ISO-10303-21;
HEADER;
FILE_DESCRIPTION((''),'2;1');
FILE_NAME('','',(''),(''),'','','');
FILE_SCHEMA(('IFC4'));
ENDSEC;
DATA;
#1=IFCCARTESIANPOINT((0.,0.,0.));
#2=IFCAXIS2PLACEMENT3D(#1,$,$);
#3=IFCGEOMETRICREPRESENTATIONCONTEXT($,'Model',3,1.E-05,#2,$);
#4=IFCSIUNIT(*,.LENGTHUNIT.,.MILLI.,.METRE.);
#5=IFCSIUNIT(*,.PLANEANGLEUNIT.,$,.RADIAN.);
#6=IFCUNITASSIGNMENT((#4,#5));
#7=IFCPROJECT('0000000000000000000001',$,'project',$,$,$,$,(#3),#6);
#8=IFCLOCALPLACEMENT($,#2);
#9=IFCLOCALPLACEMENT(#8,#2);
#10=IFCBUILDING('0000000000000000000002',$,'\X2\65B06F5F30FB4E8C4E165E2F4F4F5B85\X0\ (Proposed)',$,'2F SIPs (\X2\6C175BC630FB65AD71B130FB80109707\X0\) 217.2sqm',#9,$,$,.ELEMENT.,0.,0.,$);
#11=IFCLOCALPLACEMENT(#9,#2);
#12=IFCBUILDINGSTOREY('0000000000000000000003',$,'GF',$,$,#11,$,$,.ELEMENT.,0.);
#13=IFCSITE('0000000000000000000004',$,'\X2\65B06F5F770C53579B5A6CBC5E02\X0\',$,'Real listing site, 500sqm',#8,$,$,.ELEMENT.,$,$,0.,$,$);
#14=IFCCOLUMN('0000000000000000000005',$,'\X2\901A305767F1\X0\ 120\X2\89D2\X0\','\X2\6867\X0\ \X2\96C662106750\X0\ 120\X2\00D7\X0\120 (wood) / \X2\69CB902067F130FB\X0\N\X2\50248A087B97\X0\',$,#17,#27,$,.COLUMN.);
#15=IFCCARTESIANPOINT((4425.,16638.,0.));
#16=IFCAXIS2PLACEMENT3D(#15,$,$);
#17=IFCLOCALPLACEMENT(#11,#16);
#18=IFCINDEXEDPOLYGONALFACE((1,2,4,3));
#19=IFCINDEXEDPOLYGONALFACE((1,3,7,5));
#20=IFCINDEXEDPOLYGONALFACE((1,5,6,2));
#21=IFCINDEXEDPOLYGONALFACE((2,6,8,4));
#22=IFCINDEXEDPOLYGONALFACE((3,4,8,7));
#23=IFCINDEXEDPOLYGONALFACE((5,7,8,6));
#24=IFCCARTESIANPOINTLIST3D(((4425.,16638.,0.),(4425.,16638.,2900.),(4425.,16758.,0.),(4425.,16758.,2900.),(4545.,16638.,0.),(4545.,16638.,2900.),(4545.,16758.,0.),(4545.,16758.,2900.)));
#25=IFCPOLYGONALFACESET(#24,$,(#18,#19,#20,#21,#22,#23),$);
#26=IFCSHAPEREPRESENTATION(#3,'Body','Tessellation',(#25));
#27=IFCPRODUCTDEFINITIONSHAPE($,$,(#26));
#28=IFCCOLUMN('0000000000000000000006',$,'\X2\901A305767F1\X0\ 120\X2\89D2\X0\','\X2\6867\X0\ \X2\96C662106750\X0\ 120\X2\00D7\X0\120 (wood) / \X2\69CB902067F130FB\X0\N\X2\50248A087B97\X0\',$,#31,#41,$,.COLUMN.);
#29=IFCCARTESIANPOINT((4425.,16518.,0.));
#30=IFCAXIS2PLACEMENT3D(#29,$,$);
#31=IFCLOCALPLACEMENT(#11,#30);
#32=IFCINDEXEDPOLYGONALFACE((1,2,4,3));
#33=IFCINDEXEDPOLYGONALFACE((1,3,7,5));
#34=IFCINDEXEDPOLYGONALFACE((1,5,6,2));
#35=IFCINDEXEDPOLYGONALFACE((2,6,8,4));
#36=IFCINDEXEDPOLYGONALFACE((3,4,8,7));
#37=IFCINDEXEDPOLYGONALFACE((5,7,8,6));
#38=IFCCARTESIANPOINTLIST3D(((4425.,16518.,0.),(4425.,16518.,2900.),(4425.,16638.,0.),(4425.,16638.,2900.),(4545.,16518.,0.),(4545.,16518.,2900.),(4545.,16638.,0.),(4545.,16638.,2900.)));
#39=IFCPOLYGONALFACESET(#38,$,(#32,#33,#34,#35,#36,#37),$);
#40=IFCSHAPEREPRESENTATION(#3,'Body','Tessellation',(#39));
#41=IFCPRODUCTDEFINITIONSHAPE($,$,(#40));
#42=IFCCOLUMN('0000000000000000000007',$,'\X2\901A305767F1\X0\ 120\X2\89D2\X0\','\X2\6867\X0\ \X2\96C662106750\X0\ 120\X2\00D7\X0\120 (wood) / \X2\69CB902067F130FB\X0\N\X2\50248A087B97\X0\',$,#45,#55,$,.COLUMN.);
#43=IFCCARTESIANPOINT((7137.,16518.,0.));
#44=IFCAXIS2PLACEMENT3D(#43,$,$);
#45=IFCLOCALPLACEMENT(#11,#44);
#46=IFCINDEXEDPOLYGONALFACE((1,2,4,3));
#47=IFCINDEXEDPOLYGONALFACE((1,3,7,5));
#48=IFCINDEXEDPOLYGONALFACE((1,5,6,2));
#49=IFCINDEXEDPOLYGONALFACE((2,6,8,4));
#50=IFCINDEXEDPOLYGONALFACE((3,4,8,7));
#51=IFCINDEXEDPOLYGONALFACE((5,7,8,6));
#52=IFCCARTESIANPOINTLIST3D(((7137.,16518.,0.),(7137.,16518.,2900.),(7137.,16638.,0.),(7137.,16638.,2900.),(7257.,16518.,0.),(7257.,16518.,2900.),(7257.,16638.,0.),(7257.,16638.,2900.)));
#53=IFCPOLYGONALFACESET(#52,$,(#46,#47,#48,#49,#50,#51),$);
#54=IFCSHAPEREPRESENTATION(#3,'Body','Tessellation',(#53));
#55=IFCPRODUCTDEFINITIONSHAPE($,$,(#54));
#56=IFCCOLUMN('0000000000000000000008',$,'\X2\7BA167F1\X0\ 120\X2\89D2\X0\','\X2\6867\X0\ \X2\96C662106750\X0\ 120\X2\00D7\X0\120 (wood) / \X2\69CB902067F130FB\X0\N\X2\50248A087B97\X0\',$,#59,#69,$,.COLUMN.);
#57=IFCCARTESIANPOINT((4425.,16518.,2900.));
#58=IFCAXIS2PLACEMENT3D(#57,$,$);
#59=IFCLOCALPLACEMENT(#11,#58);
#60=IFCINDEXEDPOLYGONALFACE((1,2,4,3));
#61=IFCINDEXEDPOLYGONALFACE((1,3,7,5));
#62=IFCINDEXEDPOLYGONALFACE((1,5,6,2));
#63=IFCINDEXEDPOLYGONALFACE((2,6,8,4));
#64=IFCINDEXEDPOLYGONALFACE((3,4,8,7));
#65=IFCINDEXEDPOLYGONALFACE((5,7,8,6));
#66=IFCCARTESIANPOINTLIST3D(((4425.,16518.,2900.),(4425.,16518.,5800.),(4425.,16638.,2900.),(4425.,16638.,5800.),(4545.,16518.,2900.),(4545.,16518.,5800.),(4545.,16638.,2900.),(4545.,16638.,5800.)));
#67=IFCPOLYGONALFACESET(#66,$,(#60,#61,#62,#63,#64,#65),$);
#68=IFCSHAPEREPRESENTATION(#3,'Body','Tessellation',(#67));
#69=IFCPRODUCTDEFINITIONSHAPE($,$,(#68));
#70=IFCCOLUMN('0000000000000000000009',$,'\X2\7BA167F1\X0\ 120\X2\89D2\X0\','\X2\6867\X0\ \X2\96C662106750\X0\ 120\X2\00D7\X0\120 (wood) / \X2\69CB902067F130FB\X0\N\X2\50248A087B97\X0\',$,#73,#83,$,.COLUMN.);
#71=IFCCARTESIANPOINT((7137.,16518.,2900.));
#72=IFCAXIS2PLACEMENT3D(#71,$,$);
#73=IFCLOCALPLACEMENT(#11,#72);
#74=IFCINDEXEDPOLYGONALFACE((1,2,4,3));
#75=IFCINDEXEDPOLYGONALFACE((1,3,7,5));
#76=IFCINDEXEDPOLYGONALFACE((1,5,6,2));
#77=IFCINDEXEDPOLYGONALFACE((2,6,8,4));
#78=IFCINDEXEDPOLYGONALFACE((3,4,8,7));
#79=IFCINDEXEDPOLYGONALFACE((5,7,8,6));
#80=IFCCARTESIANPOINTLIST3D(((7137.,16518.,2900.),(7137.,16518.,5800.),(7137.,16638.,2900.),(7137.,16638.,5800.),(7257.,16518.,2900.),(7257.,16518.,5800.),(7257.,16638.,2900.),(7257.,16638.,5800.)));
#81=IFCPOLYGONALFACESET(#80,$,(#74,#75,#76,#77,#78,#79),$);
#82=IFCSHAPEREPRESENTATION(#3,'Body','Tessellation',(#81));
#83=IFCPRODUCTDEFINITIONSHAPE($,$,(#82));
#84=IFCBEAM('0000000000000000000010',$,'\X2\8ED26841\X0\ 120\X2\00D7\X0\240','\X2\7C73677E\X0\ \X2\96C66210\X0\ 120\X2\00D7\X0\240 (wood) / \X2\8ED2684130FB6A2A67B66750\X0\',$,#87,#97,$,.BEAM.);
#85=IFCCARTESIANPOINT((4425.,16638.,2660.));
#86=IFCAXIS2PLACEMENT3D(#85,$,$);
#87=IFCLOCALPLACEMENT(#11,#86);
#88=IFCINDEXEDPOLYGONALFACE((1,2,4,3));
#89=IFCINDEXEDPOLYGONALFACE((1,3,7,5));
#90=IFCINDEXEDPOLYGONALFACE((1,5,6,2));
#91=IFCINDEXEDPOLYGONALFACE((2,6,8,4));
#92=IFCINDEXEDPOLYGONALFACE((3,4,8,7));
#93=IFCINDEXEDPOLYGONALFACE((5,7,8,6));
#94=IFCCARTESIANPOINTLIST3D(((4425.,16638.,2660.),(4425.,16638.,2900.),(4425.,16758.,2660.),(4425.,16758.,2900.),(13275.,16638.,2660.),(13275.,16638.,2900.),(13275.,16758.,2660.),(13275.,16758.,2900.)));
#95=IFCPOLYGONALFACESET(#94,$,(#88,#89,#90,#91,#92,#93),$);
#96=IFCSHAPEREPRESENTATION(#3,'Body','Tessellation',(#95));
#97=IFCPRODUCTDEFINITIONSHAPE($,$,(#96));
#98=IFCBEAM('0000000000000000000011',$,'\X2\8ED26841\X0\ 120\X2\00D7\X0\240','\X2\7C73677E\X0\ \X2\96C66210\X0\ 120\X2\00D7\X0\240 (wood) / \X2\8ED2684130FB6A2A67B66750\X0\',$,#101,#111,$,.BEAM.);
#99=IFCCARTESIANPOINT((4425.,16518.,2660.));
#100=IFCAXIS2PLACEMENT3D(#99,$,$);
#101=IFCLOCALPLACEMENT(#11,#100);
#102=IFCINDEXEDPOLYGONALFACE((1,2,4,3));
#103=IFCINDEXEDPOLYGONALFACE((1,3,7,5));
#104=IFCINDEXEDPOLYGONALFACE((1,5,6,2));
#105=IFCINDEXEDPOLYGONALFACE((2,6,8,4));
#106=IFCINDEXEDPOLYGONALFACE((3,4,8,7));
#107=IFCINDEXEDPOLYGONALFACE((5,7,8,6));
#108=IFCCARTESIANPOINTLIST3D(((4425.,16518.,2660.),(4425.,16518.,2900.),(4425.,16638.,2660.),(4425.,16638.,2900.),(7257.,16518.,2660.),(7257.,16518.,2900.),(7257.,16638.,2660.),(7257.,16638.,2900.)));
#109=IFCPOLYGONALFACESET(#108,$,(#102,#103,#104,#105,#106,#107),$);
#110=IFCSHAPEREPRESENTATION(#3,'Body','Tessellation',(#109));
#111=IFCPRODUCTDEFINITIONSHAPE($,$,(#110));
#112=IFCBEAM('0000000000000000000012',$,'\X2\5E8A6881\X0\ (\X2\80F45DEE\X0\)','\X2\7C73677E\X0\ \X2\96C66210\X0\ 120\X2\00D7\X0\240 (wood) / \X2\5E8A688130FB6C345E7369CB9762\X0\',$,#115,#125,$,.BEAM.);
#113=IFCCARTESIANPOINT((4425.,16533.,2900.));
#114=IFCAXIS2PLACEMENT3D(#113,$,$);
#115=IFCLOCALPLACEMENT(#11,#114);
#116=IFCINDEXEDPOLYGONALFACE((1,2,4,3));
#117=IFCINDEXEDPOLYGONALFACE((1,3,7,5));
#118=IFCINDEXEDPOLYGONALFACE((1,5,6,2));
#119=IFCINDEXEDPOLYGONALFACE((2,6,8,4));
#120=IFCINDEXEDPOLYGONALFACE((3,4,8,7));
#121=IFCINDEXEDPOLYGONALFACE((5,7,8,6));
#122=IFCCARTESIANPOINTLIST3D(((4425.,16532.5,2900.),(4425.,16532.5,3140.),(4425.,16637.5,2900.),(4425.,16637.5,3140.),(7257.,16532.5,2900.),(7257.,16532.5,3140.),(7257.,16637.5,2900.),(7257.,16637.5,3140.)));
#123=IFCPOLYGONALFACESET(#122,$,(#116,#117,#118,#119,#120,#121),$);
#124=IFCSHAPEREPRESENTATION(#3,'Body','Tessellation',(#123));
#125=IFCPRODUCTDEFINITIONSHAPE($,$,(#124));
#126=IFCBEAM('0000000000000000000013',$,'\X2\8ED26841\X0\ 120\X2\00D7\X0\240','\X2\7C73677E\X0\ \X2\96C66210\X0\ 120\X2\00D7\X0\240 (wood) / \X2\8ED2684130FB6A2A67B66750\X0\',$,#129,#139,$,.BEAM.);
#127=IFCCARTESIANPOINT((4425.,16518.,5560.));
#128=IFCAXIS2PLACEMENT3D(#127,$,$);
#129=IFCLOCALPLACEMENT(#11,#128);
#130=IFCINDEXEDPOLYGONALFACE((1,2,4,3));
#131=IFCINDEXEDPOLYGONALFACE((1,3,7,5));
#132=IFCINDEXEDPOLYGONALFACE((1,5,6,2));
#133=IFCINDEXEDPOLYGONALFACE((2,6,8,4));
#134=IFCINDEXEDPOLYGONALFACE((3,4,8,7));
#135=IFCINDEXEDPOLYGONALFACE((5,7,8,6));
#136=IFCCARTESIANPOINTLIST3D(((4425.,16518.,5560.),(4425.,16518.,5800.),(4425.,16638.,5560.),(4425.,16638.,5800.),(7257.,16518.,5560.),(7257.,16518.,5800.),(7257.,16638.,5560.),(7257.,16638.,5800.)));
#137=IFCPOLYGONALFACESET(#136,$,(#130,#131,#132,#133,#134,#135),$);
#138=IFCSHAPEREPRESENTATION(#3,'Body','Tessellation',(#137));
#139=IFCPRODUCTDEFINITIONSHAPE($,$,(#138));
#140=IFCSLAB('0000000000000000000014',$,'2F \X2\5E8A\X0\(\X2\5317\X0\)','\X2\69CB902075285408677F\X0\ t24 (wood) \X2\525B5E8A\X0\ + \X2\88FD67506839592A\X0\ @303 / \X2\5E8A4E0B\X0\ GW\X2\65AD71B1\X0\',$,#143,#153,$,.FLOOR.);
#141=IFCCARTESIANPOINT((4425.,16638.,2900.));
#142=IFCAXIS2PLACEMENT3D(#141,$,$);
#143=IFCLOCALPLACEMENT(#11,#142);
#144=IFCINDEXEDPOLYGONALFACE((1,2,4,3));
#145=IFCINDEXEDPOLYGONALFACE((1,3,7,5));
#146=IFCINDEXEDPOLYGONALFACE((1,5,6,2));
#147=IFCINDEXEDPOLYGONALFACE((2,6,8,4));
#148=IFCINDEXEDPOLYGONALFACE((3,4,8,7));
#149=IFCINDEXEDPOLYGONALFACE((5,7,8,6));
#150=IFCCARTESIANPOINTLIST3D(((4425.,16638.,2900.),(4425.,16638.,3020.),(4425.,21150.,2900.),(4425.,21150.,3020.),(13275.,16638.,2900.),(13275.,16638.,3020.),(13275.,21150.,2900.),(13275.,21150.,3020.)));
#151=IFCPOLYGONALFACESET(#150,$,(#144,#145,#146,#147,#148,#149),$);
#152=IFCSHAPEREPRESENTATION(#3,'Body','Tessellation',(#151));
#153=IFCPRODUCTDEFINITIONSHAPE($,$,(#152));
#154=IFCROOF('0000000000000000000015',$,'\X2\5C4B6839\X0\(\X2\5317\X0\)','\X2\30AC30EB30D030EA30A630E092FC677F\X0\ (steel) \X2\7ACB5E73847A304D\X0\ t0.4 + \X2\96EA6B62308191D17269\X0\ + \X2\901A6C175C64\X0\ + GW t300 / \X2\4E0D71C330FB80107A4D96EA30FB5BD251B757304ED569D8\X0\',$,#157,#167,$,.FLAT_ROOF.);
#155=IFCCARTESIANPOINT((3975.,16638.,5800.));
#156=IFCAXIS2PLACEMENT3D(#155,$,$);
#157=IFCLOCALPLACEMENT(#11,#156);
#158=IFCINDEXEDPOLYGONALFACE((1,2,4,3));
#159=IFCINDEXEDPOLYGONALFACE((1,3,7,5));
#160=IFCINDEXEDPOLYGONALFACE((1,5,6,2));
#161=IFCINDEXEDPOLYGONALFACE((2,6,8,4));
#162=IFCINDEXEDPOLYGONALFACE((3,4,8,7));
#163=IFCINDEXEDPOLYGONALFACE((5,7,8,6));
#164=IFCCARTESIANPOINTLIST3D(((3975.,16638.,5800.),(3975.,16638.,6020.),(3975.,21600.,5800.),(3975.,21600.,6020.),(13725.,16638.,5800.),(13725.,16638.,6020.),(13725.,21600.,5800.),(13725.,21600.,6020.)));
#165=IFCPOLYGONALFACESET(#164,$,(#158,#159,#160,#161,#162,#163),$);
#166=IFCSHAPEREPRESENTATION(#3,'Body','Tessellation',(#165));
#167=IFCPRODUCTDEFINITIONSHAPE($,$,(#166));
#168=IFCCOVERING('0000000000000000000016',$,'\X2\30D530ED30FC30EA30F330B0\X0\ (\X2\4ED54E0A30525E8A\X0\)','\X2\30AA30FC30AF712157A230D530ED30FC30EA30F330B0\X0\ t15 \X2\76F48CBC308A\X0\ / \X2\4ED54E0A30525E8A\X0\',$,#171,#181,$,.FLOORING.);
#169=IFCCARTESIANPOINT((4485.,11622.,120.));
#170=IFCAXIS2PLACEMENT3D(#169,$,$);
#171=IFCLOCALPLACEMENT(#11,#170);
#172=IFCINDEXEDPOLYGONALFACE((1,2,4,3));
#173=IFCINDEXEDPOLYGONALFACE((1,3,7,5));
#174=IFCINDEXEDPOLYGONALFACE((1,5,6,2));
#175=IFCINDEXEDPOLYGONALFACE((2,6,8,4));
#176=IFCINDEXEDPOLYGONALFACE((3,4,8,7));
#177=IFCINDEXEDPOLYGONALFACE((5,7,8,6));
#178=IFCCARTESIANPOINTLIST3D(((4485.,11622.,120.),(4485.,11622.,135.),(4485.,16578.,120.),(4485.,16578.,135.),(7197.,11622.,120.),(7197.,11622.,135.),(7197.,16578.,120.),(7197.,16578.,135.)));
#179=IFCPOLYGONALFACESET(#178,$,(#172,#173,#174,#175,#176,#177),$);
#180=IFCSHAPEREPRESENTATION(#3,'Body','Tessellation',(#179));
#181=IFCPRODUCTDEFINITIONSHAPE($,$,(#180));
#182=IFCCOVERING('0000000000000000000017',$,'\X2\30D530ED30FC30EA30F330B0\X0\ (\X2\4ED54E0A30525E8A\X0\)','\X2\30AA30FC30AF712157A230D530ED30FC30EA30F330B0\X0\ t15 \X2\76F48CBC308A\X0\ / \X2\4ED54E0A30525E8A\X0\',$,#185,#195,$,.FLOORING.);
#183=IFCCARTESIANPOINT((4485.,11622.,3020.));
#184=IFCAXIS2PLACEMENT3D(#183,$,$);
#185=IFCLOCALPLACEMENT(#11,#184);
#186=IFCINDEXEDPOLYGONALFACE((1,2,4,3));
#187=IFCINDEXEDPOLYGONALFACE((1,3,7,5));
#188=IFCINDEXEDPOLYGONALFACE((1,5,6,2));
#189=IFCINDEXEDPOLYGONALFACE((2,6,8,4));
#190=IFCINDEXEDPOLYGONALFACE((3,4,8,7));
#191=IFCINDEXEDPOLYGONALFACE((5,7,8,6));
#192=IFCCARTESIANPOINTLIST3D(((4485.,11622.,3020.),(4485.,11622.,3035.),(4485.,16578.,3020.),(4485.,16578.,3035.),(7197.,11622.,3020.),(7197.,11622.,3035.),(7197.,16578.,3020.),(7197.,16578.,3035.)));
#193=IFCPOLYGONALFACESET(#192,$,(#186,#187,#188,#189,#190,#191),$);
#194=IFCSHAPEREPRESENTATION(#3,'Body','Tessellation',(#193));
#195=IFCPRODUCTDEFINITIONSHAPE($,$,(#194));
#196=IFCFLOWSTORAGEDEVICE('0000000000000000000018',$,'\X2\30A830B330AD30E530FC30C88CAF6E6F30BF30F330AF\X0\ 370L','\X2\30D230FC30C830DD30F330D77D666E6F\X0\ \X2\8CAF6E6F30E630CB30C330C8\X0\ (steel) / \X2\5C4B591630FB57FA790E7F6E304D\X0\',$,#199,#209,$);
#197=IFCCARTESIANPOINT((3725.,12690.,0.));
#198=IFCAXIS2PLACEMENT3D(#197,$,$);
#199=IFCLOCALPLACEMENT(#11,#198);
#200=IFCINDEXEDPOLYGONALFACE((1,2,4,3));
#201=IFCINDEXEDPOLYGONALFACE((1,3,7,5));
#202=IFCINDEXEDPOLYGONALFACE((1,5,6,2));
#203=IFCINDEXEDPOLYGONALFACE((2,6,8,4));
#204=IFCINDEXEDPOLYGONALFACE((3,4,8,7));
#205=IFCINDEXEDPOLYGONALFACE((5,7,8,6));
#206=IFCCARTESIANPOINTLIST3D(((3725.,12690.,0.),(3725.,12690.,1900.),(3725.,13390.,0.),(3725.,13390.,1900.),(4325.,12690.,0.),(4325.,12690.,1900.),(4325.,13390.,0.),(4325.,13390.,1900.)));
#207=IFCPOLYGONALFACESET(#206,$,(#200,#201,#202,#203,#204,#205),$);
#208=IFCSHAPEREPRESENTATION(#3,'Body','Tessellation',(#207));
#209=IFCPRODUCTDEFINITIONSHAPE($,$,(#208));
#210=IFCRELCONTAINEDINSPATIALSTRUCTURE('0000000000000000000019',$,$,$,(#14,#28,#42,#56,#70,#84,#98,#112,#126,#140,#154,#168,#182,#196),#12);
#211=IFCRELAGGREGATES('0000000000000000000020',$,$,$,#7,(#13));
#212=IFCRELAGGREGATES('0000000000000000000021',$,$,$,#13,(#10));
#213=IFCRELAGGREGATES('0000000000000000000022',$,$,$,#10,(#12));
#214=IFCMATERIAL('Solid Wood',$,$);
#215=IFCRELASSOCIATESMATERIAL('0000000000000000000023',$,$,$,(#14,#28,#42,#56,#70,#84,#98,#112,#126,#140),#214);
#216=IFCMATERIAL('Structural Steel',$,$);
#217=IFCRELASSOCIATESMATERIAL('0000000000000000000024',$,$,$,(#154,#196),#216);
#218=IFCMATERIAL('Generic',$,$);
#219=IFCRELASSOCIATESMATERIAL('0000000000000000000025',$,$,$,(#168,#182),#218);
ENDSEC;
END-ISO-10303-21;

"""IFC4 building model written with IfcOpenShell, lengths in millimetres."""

from ifc_helpers import new_model, si_unit, frame, frame_2d, origin, place, context, project, spatial, rectangle, extrude, material, element, save


model = new_model("IFC4")

# Units and contexts
model_context = context("Model", 3, precision=1e-05, world=origin())
ifc_project = project(units=[si_unit("LENGTHUNIT", "METRE", prefix="MILLI"), si_unit("PLANEANGLEUNIT", "RADIAN")], contexts=[model_context])

# Site, building, storey
site_placement = place(None, origin())
site = spatial("IfcSite", under=ifc_project, at=site_placement, Name="新潟県南魚沼市", ObjectType="Real listing site, 500sqm", CompositionType="ELEMENT", RefElevation=0.0)
building_placement = place(site_placement, origin())
building = spatial("IfcBuilding", under=site, at=building_placement, Name="新潟・二世帯住宅 (Proposed)", ObjectType="2F SIPs (気密・断熱・耐震) 217.2sqm", CompositionType="ELEMENT", ElevationOfRefHeight=0.0, ElevationOfTerrain=0.0)
storey_placement = place(building_placement, origin())
storey = spatial("IfcBuildingStorey", under=building, at=storey_placement, Name="GF", CompositionType="ELEMENT", Elevation=0.0)

# Columns
ifc_material_1 = material(Name="Solid Wood")
column_1_placement = place(storey_placement, frame((4425.0, 16638.0, 0.0)))
element("IfcColumn", 1, at=column_1_placement, inside=storey, material=ifc_material_1, Name="通し柱 120角", Description="桧 集成材 120×120 (wood) / 構造柱・N値計算", PredefinedType="COLUMN", context=model_context, shape_type="SweptSolid", body=[
    extrude(rectangle(XDim=120.0, YDim=120.0, at=frame_2d((60.0, 60.0))), frame((4425.0, 16638.0, 0.0)), (0.0, 0.0, 1.0), 2900.0),
])
column_2_placement = place(storey_placement, frame((4425.0, 16518.0, 0.0)))
element("IfcColumn", 2, at=column_2_placement, inside=storey, material=ifc_material_1, Name="通し柱 120角", Description="桧 集成材 120×120 (wood) / 構造柱・N値計算", PredefinedType="COLUMN", context=model_context, shape_type="SweptSolid", body=[
    extrude(rectangle(XDim=120.0, YDim=120.0, at=frame_2d((60.0, 60.0))), frame((4425.0, 16518.0, 0.0)), (0.0, 0.0, 1.0), 2900.0),
])
column_3_placement = place(storey_placement, frame((7137.0, 16518.0, 0.0)))
element("IfcColumn", 3, at=column_3_placement, inside=storey, material=ifc_material_1, Name="通し柱 120角", Description="桧 集成材 120×120 (wood) / 構造柱・N値計算", PredefinedType="COLUMN", context=model_context, shape_type="SweptSolid", body=[
    extrude(rectangle(XDim=120.0, YDim=120.0, at=frame_2d((60.0, 60.0))), frame((7137.0, 16518.0, 0.0)), (0.0, 0.0, 1.0), 2900.0),
])
column_4_placement = place(storey_placement, frame((4425.0, 16518.0, 2900.0)))
element("IfcColumn", 4, at=column_4_placement, inside=storey, material=ifc_material_1, Name="管柱 120角", Description="桧 集成材 120×120 (wood) / 構造柱・N値計算", PredefinedType="COLUMN", context=model_context, shape_type="SweptSolid", body=[
    extrude(rectangle(XDim=120.0, YDim=120.0, at=frame_2d((60.0, 60.0))), frame((4425.0, 16518.0, 2900.0)), (0.0, 0.0, 1.0), 2900.0),
])
column_5_placement = place(storey_placement, frame((7137.0, 16518.0, 2900.0)))
element("IfcColumn", 5, at=column_5_placement, inside=storey, material=ifc_material_1, Name="管柱 120角", Description="桧 集成材 120×120 (wood) / 構造柱・N値計算", PredefinedType="COLUMN", context=model_context, shape_type="SweptSolid", body=[
    extrude(rectangle(XDim=120.0, YDim=120.0, at=frame_2d((60.0, 60.0))), frame((7137.0, 16518.0, 2900.0)), (0.0, 0.0, 1.0), 2900.0),
])

# Beams
beam_1_placement = place(storey_placement, frame((4425.0, 16638.0, 2660.0)))
element("IfcBeam", 6, at=beam_1_placement, inside=storey, material=ifc_material_1, Name="軒桁 120×240", Description="米松 集成 120×240 (wood) / 軒桁・横架材", PredefinedType="BEAM", context=model_context, shape_type="SweptSolid", body=[
    extrude(rectangle(XDim=8850.0, YDim=120.0, at=frame_2d((4425.0, 60.0))), frame((4425.0, 16638.0, 2660.0)), (0.0, 0.0, 1.0), 240.0),
])
beam_2_placement = place(storey_placement, frame((4425.0, 16518.0, 2660.0)))
element("IfcBeam", 7, at=beam_2_placement, inside=storey, material=ifc_material_1, Name="軒桁 120×240", Description="米松 集成 120×240 (wood) / 軒桁・横架材", PredefinedType="BEAM", context=model_context, shape_type="SweptSolid", body=[
    extrude(rectangle(XDim=2832.0, YDim=120.0, at=frame_2d((1416.0, 60.0))), frame((4425.0, 16518.0, 2660.0)), (0.0, 0.0, 1.0), 240.0),
])
beam_3_placement = place(storey_placement, frame((4425.0, 16533.0, 2900.0)))
element("IfcBeam", 8, at=beam_3_placement, inside=storey, material=ifc_material_1, Name="床梁 (胴差)", Description="米松 集成 120×240 (wood) / 床梁・水平構面", PredefinedType="BEAM", context=model_context, shape_type="SweptSolid", body=[
    extrude(rectangle(XDim=2832.0, YDim=105.0, at=frame_2d((1416.0, 52.0))), frame((4425.0, 16533.0, 2900.0)), (0.0, 0.0, 1.0), 240.0),
])
beam_4_placement = place(storey_placement, frame((4425.0, 16518.0, 5560.0)))
element("IfcBeam", 9, at=beam_4_placement, inside=storey, material=ifc_material_1, Name="軒桁 120×240", Description="米松 集成 120×240 (wood) / 軒桁・横架材", PredefinedType="BEAM", context=model_context, shape_type="SweptSolid", body=[
    extrude(rectangle(XDim=2832.0, YDim=120.0, at=frame_2d((1416.0, 60.0))), frame((4425.0, 16518.0, 5560.0)), (0.0, 0.0, 1.0), 240.0),
])

# Slab
slab_1_placement = place(storey_placement, frame((4425.0, 16638.0, 2900.0)))
element("IfcSlab", 10, at=slab_1_placement, inside=storey, material=ifc_material_1, Name="2F 床(北)", Description="構造用合板 t24 (wood) 剛床 + 製材根太 @303 / 床下 GW断熱", PredefinedType="FLOOR", context=model_context, shape_type="SweptSolid", body=[
    extrude(rectangle(XDim=8850.0, YDim=4512.0, at=frame_2d((4425.0, 2256.0))), frame((4425.0, 16638.0, 2900.0)), (0.0, 0.0, 1.0), 120.0),
])

# Roof
ifc_material_2 = material(Name="Structural Steel")
for number, where, name in (
    (11, (3975.0, 16638.0, 5800.0), "屋根(北)"),
):
    element("IfcRoof", number, at=place(storey_placement, frame(where)), inside=storey, material=ifc_material_2, Name=name, Description="ガルバリウム鋼板 (steel) 立平葺き t0.4 + 雪止め金物 + 通気層 + GW t300 / 不燃・耐積雪・寒冷地仕様", PredefinedType="FLAT_ROOF", context=model_context, shape_type="SweptSolid", body=[
        extrude(rectangle(XDim=9750.0, YDim=4962.0, at=frame_2d((4875.0, 2481.0))), frame((3975.0, 16638.0, 5800.0)), (0.0, 0.0, 1.0), 220.0),
    ])

# Coverings
ifc_material_3 = material(Name="Generic")
covering_1_placement = place(storey_placement, frame((4485.0, 11622.0, 120.0)))
element("IfcCovering", 12, at=covering_1_placement, inside=storey, material=ifc_material_3, Name="フローリング (仕上げ床)", Description="オーク無垢フローリング t15 直貼り / 仕上げ床", PredefinedType="FLOORING", context=model_context, shape_type="SweptSolid", body=[
    extrude(rectangle(XDim=2712.0, YDim=4956.0, at=frame_2d((1356.0, 2478.0))), frame((4485.0, 11622.0, 120.0)), (0.0, 0.0, 1.0), 15.0),
])
covering_2_placement = place(storey_placement, frame((4485.0, 11622.0, 3020.0)))
element("IfcCovering", 13, at=covering_2_placement, inside=storey, material=ifc_material_3, Name="フローリング (仕上げ床)", Description="オーク無垢フローリング t15 直貼り / 仕上げ床", PredefinedType="FLOORING", context=model_context, shape_type="SweptSolid", body=[
    extrude(rectangle(XDim=2712.0, YDim=4956.0, at=frame_2d((1356.0, 2478.0))), frame((4485.0, 11622.0, 3020.0)), (0.0, 0.0, 1.0), 15.0),
])

# Flow storage device
flow_storage_device_placement = place(storey_placement, frame((3725.0, 12690.0, 0.0)))
element("IfcFlowStorageDevice", 14, at=flow_storage_device_placement, inside=storey, material=ifc_material_2, Name="エコキュート貯湯タンク 370L", Description="ヒートポンプ給湯 貯湯ユニット (steel) / 屋外・基礎置き", context=model_context, shape_type="SweptSolid", body=[
    extrude(rectangle(XDim=600.0, YDim=700.0, at=frame_2d((300.0, 350.0))), frame((3725.0, 12690.0, 0.0)), (0.0, 0.0, 1.0), 1900.0),
])

save(model, "model.ifc")
